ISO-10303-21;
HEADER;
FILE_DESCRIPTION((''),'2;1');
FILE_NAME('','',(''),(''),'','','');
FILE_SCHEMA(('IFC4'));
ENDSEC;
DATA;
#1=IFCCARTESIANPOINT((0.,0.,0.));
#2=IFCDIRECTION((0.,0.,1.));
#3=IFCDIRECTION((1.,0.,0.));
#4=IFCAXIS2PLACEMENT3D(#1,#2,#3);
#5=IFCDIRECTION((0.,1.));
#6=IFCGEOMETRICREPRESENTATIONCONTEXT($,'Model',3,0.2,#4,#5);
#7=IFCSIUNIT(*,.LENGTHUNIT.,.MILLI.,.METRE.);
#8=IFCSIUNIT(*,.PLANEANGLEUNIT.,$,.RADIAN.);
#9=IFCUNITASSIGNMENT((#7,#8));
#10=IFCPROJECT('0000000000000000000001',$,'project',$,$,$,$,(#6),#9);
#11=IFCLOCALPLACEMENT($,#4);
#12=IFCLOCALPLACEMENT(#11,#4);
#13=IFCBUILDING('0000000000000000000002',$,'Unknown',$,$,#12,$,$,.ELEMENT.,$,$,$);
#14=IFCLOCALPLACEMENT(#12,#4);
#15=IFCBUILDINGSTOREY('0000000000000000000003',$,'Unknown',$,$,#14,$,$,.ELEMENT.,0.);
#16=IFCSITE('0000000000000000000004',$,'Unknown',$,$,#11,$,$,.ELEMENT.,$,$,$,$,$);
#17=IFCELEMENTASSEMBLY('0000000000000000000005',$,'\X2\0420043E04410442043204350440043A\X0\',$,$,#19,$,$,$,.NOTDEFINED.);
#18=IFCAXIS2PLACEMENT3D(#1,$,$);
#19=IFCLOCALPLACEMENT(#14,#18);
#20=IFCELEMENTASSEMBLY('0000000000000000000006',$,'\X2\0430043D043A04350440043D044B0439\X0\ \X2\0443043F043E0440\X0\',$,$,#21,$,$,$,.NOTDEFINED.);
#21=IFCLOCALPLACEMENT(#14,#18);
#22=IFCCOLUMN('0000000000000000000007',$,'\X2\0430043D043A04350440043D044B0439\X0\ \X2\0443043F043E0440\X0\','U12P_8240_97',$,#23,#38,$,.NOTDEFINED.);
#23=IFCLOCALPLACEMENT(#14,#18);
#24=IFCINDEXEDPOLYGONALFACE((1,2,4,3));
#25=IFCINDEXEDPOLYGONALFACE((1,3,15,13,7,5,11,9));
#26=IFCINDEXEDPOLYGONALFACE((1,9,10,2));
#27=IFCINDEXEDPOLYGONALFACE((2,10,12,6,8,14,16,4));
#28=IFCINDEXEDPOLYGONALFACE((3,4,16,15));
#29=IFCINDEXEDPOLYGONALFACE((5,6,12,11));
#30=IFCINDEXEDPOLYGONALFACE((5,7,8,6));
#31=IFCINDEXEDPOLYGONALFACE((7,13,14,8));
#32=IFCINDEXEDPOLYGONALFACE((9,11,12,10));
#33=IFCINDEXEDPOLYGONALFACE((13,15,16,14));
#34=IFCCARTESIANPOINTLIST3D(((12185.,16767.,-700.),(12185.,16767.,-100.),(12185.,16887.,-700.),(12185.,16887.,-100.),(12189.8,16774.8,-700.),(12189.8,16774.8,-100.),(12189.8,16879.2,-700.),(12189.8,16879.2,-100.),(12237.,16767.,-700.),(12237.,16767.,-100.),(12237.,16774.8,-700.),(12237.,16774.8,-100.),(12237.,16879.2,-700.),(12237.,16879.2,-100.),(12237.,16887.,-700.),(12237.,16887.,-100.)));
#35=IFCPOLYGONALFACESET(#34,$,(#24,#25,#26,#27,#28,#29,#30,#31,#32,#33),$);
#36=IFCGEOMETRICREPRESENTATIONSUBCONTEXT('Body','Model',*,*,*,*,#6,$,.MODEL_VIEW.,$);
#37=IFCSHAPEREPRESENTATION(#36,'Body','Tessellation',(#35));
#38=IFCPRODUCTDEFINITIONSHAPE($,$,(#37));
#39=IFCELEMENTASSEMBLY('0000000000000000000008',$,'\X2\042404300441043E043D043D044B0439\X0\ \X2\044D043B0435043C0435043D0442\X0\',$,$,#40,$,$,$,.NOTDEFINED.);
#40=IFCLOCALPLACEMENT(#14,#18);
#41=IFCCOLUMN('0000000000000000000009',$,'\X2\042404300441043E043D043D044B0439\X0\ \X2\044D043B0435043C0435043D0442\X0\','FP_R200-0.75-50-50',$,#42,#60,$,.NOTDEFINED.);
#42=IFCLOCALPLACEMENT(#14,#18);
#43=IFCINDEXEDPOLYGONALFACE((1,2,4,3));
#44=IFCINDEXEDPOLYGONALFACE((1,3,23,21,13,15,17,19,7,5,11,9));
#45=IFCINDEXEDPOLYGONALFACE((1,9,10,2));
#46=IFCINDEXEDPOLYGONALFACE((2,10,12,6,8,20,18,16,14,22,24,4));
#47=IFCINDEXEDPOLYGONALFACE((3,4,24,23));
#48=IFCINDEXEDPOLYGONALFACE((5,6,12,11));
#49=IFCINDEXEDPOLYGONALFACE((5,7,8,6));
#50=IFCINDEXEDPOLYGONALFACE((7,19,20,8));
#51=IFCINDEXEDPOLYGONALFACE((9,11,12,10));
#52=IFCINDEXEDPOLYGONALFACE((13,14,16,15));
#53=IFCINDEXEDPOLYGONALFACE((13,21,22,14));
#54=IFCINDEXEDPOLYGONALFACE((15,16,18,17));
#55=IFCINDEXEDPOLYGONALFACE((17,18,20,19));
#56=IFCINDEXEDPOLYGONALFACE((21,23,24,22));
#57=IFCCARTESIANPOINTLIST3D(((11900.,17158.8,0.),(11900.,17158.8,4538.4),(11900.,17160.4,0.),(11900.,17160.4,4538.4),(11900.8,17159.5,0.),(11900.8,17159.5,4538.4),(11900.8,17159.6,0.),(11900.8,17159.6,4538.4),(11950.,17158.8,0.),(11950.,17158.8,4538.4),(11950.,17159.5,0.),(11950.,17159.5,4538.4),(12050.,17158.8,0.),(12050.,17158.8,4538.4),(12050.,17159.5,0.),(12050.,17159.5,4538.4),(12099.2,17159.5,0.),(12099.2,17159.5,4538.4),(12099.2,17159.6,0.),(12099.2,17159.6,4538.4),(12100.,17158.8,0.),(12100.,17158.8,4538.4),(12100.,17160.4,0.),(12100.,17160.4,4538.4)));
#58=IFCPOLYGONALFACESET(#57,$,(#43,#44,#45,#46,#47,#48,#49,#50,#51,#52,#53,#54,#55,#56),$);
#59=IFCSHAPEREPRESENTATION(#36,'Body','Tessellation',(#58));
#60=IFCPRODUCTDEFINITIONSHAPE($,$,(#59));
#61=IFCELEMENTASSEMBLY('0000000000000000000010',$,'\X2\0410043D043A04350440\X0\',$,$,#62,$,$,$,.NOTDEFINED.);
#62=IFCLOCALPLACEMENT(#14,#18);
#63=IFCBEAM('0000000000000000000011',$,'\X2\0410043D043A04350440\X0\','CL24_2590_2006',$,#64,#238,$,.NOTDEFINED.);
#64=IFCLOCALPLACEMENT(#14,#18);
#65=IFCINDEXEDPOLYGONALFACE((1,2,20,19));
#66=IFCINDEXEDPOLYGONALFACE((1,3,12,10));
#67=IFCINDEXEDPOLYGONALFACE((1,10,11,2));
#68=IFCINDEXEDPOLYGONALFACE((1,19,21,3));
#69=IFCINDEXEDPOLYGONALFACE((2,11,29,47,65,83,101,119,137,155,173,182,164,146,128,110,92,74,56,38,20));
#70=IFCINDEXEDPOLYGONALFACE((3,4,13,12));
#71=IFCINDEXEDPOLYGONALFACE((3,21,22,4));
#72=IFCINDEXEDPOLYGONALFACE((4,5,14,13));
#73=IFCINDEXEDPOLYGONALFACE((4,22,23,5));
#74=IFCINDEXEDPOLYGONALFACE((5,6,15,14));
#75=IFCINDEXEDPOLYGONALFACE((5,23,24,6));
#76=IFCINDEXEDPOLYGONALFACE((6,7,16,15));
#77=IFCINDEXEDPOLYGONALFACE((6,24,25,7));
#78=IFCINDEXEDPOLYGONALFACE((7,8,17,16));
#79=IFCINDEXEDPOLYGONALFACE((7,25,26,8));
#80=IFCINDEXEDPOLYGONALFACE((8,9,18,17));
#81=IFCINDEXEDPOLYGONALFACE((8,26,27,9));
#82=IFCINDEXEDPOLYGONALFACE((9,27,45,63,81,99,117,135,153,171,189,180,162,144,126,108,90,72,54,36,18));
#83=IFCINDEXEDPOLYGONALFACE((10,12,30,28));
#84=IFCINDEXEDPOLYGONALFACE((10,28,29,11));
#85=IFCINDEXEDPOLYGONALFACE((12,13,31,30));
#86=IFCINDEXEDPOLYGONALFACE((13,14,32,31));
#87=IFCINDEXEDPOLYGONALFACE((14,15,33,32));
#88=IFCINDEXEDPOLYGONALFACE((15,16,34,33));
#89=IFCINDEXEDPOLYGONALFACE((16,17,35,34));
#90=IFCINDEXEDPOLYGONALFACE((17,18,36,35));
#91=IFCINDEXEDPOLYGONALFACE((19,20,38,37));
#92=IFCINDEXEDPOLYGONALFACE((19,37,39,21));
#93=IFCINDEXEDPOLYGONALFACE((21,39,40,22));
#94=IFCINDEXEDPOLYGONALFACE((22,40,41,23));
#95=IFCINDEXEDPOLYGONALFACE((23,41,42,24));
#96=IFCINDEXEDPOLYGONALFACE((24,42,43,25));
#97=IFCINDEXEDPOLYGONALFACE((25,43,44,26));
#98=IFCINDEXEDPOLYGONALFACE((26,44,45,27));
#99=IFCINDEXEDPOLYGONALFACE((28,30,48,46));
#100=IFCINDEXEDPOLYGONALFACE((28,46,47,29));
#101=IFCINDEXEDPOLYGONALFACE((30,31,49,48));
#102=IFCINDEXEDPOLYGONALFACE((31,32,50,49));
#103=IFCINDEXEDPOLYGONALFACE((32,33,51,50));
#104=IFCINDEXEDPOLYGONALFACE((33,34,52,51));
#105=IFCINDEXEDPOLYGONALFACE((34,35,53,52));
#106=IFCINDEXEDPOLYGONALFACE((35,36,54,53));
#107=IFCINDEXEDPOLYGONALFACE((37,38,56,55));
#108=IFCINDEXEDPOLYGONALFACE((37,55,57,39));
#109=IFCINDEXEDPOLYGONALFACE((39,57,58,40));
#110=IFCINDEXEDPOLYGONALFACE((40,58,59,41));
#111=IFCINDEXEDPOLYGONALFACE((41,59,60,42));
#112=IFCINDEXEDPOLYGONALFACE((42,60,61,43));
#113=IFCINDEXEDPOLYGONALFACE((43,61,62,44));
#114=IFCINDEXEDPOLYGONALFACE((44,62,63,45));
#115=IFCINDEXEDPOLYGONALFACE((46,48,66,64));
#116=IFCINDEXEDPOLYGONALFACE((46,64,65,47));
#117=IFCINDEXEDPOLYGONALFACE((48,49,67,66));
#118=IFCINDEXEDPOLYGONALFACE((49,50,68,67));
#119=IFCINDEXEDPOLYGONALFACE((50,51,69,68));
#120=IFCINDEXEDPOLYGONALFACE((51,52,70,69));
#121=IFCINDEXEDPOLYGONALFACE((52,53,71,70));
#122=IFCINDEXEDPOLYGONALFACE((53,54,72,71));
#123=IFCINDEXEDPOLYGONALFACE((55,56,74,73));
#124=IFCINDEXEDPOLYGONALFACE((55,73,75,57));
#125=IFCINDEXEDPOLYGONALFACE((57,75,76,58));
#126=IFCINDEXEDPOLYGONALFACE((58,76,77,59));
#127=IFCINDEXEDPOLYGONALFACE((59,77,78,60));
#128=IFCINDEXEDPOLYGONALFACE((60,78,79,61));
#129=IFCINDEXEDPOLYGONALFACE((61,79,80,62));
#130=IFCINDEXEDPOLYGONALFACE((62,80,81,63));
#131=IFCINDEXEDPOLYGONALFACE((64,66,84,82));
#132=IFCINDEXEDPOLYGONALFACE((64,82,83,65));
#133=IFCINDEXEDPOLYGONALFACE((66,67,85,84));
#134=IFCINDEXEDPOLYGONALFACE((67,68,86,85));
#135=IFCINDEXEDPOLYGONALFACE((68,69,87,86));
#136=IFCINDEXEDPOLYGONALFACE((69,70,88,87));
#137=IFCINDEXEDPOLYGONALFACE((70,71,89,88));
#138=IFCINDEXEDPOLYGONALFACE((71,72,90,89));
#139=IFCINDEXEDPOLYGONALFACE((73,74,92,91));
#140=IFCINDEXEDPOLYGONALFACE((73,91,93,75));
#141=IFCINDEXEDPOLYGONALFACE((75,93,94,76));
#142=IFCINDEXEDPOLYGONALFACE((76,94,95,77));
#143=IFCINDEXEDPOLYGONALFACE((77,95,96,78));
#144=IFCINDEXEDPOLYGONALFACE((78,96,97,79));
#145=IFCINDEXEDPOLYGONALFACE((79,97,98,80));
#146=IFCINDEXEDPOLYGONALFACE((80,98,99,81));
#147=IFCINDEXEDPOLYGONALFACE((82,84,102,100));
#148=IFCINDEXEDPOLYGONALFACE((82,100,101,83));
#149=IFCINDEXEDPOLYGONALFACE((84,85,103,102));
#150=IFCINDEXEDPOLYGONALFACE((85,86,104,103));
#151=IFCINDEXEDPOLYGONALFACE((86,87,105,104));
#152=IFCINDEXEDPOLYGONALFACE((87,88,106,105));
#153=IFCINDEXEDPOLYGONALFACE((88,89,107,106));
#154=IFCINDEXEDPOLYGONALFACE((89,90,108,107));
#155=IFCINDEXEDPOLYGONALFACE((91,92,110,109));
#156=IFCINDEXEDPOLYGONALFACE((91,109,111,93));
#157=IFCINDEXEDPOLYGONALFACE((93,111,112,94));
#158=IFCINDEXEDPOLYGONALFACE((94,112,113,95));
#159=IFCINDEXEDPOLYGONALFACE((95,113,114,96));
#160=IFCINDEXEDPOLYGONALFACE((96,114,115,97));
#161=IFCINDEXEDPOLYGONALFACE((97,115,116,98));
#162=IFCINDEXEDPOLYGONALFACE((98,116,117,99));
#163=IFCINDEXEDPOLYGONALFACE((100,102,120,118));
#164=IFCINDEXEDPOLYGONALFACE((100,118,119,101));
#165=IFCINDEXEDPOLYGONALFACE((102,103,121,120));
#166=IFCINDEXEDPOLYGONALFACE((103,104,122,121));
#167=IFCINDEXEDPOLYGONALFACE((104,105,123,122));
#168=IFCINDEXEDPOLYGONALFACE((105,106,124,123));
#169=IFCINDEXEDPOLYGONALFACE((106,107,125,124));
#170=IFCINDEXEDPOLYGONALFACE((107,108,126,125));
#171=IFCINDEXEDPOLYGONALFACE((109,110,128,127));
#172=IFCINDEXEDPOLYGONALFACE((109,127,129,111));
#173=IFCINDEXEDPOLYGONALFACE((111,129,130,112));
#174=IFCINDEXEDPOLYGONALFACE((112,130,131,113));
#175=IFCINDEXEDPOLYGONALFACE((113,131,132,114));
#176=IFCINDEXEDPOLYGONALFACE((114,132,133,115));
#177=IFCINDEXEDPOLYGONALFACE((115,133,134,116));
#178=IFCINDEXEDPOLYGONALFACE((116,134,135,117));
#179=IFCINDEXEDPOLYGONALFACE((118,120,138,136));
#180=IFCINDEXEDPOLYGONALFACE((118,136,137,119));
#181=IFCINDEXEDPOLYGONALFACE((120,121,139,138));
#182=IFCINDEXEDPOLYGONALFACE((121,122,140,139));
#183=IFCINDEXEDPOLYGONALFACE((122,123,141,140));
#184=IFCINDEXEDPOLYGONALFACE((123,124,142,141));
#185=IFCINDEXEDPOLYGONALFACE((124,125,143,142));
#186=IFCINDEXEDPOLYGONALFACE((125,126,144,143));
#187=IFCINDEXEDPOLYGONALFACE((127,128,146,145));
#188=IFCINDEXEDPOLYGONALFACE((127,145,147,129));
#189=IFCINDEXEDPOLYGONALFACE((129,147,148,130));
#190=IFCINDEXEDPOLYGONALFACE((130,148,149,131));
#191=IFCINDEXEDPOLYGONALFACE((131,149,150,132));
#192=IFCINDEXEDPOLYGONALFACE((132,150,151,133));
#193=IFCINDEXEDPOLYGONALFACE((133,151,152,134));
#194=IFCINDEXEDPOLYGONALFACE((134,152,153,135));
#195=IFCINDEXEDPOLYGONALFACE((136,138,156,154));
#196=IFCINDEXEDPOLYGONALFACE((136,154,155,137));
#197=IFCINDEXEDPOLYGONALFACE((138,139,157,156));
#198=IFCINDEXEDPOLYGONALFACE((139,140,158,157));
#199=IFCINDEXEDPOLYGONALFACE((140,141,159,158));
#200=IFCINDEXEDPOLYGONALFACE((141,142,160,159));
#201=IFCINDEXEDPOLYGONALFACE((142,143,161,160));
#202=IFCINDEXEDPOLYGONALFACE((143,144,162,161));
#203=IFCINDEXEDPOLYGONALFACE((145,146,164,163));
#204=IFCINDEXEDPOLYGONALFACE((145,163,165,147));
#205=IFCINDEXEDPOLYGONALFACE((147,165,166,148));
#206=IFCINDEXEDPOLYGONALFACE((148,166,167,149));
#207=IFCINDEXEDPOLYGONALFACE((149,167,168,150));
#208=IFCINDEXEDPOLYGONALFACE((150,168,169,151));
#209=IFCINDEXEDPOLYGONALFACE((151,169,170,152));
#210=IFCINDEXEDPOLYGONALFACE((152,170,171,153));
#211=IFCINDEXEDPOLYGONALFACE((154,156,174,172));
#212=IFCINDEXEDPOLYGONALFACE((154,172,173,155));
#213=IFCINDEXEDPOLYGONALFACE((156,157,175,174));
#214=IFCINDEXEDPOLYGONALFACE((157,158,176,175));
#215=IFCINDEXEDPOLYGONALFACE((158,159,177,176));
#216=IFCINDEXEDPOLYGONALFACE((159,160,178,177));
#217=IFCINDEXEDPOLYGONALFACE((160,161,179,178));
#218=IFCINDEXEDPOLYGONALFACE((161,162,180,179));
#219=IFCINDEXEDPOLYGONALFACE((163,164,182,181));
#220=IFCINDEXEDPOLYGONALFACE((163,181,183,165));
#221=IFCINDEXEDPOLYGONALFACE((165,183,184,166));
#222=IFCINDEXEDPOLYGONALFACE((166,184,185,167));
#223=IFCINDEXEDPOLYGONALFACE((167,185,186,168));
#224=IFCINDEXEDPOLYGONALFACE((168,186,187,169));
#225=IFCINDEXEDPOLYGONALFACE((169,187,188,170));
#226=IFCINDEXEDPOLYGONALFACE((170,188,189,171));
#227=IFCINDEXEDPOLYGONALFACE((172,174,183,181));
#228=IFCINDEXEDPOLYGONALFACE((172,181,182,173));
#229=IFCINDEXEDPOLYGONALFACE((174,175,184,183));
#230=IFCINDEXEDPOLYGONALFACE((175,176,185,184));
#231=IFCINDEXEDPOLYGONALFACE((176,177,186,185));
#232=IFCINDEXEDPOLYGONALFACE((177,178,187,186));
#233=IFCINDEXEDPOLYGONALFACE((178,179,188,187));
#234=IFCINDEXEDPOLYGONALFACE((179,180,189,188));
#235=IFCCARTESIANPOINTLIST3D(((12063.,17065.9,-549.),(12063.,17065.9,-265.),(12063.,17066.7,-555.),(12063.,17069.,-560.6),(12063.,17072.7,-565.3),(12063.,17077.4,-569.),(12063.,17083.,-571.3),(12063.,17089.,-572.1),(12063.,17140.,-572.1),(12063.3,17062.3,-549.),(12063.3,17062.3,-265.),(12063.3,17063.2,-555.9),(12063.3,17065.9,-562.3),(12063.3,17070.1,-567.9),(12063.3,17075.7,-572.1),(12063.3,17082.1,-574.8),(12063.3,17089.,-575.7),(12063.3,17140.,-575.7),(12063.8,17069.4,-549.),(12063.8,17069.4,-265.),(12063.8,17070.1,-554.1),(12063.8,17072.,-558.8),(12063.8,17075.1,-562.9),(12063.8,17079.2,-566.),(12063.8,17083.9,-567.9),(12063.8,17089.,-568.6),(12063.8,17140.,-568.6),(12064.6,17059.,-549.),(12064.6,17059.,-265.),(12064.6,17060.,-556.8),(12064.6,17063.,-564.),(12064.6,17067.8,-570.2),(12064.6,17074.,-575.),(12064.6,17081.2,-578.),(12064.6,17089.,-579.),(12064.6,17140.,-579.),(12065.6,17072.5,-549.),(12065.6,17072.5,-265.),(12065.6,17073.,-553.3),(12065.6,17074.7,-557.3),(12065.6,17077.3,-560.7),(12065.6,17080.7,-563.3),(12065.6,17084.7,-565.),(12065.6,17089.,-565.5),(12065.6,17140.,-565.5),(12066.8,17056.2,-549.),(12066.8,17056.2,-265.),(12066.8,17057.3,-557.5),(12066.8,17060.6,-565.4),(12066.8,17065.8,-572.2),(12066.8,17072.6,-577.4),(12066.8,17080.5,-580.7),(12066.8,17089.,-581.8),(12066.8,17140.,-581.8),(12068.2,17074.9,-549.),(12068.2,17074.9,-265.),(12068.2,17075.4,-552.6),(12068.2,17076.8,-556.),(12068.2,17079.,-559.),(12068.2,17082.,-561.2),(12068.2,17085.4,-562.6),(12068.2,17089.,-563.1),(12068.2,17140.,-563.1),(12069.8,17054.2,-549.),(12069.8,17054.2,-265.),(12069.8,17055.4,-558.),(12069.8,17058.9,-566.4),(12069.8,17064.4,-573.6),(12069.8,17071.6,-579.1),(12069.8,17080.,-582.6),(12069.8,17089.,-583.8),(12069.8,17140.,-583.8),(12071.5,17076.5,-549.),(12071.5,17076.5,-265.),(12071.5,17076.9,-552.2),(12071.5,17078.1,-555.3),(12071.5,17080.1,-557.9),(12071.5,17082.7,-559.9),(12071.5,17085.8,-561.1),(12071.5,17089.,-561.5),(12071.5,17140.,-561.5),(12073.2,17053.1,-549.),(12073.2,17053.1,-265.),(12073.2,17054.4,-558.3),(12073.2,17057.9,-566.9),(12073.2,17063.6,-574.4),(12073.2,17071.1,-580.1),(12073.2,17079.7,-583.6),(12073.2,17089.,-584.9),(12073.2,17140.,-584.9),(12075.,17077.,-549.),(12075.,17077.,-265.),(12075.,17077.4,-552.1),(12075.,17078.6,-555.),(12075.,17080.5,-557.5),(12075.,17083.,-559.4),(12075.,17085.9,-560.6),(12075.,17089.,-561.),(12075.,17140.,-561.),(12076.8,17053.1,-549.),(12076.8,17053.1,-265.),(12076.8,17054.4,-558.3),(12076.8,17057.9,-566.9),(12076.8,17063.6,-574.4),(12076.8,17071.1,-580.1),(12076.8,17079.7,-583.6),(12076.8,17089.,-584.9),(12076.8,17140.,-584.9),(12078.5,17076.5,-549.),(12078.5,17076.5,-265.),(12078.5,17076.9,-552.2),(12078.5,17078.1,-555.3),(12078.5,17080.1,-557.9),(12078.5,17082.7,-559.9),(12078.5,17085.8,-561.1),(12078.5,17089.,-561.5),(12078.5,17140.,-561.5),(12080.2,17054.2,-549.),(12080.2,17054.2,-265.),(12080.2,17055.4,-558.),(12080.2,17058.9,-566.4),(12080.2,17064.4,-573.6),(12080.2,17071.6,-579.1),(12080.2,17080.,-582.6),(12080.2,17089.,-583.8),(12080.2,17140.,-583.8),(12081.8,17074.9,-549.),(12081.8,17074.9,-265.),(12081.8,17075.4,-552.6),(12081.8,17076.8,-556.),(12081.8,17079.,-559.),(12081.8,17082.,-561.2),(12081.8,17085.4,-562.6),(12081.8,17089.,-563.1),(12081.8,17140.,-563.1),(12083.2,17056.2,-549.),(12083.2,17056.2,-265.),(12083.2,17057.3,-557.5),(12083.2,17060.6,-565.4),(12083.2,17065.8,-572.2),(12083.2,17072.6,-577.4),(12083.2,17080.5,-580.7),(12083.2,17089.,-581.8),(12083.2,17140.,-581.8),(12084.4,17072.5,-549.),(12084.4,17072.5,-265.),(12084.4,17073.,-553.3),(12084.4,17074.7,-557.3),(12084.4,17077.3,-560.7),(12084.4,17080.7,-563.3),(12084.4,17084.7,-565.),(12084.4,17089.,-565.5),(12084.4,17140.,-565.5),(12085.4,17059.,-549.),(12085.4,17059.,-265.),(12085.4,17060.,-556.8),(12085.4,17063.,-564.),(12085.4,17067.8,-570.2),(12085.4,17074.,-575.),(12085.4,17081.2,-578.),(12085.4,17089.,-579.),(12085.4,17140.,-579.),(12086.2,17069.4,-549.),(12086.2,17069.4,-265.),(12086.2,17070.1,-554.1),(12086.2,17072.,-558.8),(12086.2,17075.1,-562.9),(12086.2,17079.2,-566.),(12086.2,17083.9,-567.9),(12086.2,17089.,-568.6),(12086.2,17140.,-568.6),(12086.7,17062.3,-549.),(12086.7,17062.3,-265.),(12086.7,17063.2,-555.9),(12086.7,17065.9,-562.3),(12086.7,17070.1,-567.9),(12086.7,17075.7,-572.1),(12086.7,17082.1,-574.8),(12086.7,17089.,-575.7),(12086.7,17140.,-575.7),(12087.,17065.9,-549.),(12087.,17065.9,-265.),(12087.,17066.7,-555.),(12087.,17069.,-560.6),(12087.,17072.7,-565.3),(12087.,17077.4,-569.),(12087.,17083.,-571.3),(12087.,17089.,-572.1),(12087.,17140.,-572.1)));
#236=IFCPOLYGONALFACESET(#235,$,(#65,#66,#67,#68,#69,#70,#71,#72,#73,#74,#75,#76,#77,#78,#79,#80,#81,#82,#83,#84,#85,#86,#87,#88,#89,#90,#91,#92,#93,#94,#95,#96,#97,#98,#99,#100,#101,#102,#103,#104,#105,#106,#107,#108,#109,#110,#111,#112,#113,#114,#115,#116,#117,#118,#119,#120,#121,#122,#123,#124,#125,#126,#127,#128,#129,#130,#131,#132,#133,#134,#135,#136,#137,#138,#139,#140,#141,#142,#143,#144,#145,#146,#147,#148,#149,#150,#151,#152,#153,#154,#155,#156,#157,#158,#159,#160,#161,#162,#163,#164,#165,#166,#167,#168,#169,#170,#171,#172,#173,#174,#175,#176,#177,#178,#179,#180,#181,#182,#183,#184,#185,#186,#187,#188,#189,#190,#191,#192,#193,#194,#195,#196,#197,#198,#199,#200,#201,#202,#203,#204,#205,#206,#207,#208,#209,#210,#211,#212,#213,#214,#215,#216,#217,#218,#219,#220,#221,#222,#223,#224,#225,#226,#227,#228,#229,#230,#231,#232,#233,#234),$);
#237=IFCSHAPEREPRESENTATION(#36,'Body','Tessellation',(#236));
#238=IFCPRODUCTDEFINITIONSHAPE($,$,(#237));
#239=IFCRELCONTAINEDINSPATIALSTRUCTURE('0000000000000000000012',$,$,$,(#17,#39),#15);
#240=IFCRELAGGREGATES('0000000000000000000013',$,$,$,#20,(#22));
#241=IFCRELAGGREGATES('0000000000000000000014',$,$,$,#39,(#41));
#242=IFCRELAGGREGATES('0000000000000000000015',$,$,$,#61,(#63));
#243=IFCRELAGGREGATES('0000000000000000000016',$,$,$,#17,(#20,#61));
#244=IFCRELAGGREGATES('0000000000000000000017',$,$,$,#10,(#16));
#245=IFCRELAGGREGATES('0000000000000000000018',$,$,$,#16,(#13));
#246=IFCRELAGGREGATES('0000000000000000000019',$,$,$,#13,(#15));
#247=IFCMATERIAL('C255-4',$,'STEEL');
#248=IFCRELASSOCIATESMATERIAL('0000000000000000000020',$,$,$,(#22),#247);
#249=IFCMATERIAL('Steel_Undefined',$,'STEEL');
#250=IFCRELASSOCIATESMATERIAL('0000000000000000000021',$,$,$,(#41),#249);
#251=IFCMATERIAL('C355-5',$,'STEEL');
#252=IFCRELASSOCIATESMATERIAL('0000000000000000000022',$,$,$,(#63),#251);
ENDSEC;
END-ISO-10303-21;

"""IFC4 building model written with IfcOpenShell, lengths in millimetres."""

from ifc_helpers import new_model, entity, si_unit, direction, frame, origin_with_axes, place, context, subcontext, project, spatial, line, indexed_curve, outline, extrude, material, element, aggregate, save


model = new_model("IFC4")

# Units and contexts
model_context = context("Model", 3, precision=0.2, world=origin_with_axes(), true_north=direction((0.0, 1.0)))
body_context = subcontext(model_context, "Body", "Model", "MODEL_VIEW")
ifc_project = project(units=[si_unit("LENGTHUNIT", "METRE", prefix="MILLI"), si_unit("PLANEANGLEUNIT", "RADIAN")], contexts=[model_context])

# Site, building, storey
site_placement = place(None, origin_with_axes())
site = spatial("IfcSite", under=ifc_project, at=site_placement, Name="Unknown", CompositionType="ELEMENT")
building_placement = place(site_placement, origin_with_axes())
building = spatial("IfcBuilding", under=site, at=building_placement, Name="Unknown", CompositionType="ELEMENT")
storey_placement = place(building_placement, origin_with_axes())
storey = spatial("IfcBuildingStorey", under=building, at=storey_placement, Name="Unknown", CompositionType="ELEMENT", Elevation=0.0)

# Element assemblies, column
assembly_1_placement = place(storey_placement, frame((12000.0, 16827.0, -300.0), z_axis=(-1.0, 0.0, 0.0), x_axis=(0.0, 0.0, -1.0)))
assembly_1 = element("IfcElementAssembly", 1, at=assembly_1_placement, inside=storey, Name="Ростверк", PredefinedType="NOTDEFINED")
assembly_2_placement = place(assembly_1_placement, frame((400.0, 0.0, -211.0), z_axis=(0.0, 0.0, -1.0), x_axis=(-1.0, 0.0, 0.0)))
assembly_2 = element("IfcElementAssembly", 2, at=assembly_2_placement, Name="анкерный упор", PredefinedType="NOTDEFINED")
ifc_material_1 = material(Name="C255-4", Category="STEEL")
column_1_placement = place(assembly_2_placement, origin_with_axes())
column_1 = element("IfcColumn", 3, at=column_1_placement, material=ifc_material_1, Name="анкерный упор", Description="U12P_8240_97", PredefinedType="NOTDEFINED", context=body_context, shape_type="SolidModel", body=[
    extrude(outline(indexed_curve([(-26.0, -60.0), (26.0, -60.0), (26.0, -52.2), (-21.2, -52.2), (-21.2, 52.2), (26.0, 52.2), (26.0, 60.0), (-26.0, 60.0)], segments=[line(1, 2, 3, 4, 5, 6, 7, 8, 1)])), frame((0.0, 0.0, 0.0), z_axis=(-1.0, 0.0, 0.0), x_axis=(0.0, 0.0, 1.0)), (0.0, 0.0, -1.0), 600.0),
])
aggregate(assembly_2, [column_1])

# Element assembly, column
assembly_3_placement = place(storey_placement, frame((12000.0, 17160.0, 0.0), z_axis=(0.0, -1.0, 0.0), x_axis=(0.0, 0.0, 1.0)))
assembly_3 = element("IfcElementAssembly", 4, at=assembly_3_placement, inside=storey, Name="Фасонный элемент", PredefinedType="NOTDEFINED")
ifc_material_2 = material(Name="Steel_Undefined", Category="STEEL")
column_2_placement = place(assembly_3_placement, origin_with_axes())
column_2 = element("IfcColumn", 5, at=column_2_placement, material=ifc_material_2, Name="Фасонный элемент", Description="FP_R200-0.75-50-50", PredefinedType="NOTDEFINED", context=body_context, shape_type="SolidModel", body=[
    extrude(outline(indexed_curve([(-0.4, -100.0), (1.2, -100.0), (1.2, -50.0), (0.5, -50.0), (0.5, -99.2), (0.4, -99.2), (0.4, 99.2), (0.5, 99.2), (0.5, 50.0), (1.2, 50.0), (1.2, 100.0), (-0.4, 100.0)], segments=[line(1, 2, 3, 4, 5, 6, 7, 8, 9, 10, 11, 12, 1)])), frame((0.0, 0.0, 0.0), z_axis=(-1.0, 0.0, 0.0), x_axis=(0.0, 0.0, 1.0)), (0.0, 0.0, -1.0), 4538.4),
])
aggregate(assembly_3, [column_2])

# Element assembly, beam, voiding feature
assembly_4_placement = place(assembly_1_placement, frame((-215.0, -238.0, -75.0), z_axis=(0.0, -1.0, 0.0), x_axis=(1.0, 0.0, 0.0)))
assembly_4 = element("IfcElementAssembly", 6, at=assembly_4_placement, Name="Анкер", PredefinedType="NOTDEFINED")
ifc_material_3 = material(Name="C355-5", Category="STEEL")
beam_1_placement = place(assembly_4_placement, origin_with_axes())
beam_1 = element("IfcBeam", 7, at=beam_1_placement, material=ifc_material_3, Name="Анкер", Description="CL24_2590_2006", PredefinedType="NOTDEFINED", context=body_context, shape_type="SolidModel", body=[
    entity("IfcSweptDiskSolid", entity("IfcIndexedPolyCurve", entity("IfcCartesianPointList3D", [[0.0, 0.0, 0.0], [464.0, 0.0, 0.0], [481.0, 0.0, 7.0], [488.0, 0.0, 24.0], [488.0, 0.0, 75.0]]), [entity("IfcLineIndex", [1, 2]), entity("IfcArcIndex", [2, 3, 4]), entity("IfcLineIndex", [4, 5])]), 12.0),
])
voiding_feature_1_placement = place(beam_1_placement, frame((0.0, 0.0, 0.0), z_axis=(0.0, -1.0, 0.0), x_axis=(1.0, 0.0, 0.0)))
element("IfcVoidingFeature", 8, at=voiding_feature_1_placement, cuts=beam_1, Name="Анкер", PredefinedType="HOLE", context=body_context, shape_type="SolidModel", body=[
    extrude(outline(indexed_curve([(12.5, 0.0), (12.2, 2.8), (11.3, 5.4), (9.8, 7.8), (7.8, 9.8), (5.4, 11.3), (2.8, 12.2), (0.0, 12.5), (-2.8, 12.2), (-5.4, 11.3), (-7.8, 9.8), (-9.8, 7.8), (-11.3, 5.4), (-12.2, 2.8), (-12.5, 0.0), (-12.2, -2.8), (-11.3, -5.4), (-9.8, -7.8), (-7.8, -9.8), (-5.4, -11.3), (-2.8, -12.2), (0.0, -12.5), (2.8, -12.2), (5.4, -11.3), (7.8, -9.8), (9.8, -7.8), (11.3, -5.4), (12.2, -2.8)], segments=[line(1, 2, 3, 4, 5, 6, 7, 8, 9, 10, 11, 12, 13, 14, 15, 16, 17, 18, 19, 20, 21, 22, 23, 24, 25, 26, 27, 28, 1)])), frame((0.0, 0.0, 0.0), z_axis=(-1.0, 0.0, 0.0), x_axis=(0.0, 0.0, 1.0)), (0.0, 0.0, -1.0), 180.0),
])
aggregate(assembly_4, [beam_1])

aggregate(assembly_1, [assembly_2, assembly_4])

save(model, "model.ifc")
